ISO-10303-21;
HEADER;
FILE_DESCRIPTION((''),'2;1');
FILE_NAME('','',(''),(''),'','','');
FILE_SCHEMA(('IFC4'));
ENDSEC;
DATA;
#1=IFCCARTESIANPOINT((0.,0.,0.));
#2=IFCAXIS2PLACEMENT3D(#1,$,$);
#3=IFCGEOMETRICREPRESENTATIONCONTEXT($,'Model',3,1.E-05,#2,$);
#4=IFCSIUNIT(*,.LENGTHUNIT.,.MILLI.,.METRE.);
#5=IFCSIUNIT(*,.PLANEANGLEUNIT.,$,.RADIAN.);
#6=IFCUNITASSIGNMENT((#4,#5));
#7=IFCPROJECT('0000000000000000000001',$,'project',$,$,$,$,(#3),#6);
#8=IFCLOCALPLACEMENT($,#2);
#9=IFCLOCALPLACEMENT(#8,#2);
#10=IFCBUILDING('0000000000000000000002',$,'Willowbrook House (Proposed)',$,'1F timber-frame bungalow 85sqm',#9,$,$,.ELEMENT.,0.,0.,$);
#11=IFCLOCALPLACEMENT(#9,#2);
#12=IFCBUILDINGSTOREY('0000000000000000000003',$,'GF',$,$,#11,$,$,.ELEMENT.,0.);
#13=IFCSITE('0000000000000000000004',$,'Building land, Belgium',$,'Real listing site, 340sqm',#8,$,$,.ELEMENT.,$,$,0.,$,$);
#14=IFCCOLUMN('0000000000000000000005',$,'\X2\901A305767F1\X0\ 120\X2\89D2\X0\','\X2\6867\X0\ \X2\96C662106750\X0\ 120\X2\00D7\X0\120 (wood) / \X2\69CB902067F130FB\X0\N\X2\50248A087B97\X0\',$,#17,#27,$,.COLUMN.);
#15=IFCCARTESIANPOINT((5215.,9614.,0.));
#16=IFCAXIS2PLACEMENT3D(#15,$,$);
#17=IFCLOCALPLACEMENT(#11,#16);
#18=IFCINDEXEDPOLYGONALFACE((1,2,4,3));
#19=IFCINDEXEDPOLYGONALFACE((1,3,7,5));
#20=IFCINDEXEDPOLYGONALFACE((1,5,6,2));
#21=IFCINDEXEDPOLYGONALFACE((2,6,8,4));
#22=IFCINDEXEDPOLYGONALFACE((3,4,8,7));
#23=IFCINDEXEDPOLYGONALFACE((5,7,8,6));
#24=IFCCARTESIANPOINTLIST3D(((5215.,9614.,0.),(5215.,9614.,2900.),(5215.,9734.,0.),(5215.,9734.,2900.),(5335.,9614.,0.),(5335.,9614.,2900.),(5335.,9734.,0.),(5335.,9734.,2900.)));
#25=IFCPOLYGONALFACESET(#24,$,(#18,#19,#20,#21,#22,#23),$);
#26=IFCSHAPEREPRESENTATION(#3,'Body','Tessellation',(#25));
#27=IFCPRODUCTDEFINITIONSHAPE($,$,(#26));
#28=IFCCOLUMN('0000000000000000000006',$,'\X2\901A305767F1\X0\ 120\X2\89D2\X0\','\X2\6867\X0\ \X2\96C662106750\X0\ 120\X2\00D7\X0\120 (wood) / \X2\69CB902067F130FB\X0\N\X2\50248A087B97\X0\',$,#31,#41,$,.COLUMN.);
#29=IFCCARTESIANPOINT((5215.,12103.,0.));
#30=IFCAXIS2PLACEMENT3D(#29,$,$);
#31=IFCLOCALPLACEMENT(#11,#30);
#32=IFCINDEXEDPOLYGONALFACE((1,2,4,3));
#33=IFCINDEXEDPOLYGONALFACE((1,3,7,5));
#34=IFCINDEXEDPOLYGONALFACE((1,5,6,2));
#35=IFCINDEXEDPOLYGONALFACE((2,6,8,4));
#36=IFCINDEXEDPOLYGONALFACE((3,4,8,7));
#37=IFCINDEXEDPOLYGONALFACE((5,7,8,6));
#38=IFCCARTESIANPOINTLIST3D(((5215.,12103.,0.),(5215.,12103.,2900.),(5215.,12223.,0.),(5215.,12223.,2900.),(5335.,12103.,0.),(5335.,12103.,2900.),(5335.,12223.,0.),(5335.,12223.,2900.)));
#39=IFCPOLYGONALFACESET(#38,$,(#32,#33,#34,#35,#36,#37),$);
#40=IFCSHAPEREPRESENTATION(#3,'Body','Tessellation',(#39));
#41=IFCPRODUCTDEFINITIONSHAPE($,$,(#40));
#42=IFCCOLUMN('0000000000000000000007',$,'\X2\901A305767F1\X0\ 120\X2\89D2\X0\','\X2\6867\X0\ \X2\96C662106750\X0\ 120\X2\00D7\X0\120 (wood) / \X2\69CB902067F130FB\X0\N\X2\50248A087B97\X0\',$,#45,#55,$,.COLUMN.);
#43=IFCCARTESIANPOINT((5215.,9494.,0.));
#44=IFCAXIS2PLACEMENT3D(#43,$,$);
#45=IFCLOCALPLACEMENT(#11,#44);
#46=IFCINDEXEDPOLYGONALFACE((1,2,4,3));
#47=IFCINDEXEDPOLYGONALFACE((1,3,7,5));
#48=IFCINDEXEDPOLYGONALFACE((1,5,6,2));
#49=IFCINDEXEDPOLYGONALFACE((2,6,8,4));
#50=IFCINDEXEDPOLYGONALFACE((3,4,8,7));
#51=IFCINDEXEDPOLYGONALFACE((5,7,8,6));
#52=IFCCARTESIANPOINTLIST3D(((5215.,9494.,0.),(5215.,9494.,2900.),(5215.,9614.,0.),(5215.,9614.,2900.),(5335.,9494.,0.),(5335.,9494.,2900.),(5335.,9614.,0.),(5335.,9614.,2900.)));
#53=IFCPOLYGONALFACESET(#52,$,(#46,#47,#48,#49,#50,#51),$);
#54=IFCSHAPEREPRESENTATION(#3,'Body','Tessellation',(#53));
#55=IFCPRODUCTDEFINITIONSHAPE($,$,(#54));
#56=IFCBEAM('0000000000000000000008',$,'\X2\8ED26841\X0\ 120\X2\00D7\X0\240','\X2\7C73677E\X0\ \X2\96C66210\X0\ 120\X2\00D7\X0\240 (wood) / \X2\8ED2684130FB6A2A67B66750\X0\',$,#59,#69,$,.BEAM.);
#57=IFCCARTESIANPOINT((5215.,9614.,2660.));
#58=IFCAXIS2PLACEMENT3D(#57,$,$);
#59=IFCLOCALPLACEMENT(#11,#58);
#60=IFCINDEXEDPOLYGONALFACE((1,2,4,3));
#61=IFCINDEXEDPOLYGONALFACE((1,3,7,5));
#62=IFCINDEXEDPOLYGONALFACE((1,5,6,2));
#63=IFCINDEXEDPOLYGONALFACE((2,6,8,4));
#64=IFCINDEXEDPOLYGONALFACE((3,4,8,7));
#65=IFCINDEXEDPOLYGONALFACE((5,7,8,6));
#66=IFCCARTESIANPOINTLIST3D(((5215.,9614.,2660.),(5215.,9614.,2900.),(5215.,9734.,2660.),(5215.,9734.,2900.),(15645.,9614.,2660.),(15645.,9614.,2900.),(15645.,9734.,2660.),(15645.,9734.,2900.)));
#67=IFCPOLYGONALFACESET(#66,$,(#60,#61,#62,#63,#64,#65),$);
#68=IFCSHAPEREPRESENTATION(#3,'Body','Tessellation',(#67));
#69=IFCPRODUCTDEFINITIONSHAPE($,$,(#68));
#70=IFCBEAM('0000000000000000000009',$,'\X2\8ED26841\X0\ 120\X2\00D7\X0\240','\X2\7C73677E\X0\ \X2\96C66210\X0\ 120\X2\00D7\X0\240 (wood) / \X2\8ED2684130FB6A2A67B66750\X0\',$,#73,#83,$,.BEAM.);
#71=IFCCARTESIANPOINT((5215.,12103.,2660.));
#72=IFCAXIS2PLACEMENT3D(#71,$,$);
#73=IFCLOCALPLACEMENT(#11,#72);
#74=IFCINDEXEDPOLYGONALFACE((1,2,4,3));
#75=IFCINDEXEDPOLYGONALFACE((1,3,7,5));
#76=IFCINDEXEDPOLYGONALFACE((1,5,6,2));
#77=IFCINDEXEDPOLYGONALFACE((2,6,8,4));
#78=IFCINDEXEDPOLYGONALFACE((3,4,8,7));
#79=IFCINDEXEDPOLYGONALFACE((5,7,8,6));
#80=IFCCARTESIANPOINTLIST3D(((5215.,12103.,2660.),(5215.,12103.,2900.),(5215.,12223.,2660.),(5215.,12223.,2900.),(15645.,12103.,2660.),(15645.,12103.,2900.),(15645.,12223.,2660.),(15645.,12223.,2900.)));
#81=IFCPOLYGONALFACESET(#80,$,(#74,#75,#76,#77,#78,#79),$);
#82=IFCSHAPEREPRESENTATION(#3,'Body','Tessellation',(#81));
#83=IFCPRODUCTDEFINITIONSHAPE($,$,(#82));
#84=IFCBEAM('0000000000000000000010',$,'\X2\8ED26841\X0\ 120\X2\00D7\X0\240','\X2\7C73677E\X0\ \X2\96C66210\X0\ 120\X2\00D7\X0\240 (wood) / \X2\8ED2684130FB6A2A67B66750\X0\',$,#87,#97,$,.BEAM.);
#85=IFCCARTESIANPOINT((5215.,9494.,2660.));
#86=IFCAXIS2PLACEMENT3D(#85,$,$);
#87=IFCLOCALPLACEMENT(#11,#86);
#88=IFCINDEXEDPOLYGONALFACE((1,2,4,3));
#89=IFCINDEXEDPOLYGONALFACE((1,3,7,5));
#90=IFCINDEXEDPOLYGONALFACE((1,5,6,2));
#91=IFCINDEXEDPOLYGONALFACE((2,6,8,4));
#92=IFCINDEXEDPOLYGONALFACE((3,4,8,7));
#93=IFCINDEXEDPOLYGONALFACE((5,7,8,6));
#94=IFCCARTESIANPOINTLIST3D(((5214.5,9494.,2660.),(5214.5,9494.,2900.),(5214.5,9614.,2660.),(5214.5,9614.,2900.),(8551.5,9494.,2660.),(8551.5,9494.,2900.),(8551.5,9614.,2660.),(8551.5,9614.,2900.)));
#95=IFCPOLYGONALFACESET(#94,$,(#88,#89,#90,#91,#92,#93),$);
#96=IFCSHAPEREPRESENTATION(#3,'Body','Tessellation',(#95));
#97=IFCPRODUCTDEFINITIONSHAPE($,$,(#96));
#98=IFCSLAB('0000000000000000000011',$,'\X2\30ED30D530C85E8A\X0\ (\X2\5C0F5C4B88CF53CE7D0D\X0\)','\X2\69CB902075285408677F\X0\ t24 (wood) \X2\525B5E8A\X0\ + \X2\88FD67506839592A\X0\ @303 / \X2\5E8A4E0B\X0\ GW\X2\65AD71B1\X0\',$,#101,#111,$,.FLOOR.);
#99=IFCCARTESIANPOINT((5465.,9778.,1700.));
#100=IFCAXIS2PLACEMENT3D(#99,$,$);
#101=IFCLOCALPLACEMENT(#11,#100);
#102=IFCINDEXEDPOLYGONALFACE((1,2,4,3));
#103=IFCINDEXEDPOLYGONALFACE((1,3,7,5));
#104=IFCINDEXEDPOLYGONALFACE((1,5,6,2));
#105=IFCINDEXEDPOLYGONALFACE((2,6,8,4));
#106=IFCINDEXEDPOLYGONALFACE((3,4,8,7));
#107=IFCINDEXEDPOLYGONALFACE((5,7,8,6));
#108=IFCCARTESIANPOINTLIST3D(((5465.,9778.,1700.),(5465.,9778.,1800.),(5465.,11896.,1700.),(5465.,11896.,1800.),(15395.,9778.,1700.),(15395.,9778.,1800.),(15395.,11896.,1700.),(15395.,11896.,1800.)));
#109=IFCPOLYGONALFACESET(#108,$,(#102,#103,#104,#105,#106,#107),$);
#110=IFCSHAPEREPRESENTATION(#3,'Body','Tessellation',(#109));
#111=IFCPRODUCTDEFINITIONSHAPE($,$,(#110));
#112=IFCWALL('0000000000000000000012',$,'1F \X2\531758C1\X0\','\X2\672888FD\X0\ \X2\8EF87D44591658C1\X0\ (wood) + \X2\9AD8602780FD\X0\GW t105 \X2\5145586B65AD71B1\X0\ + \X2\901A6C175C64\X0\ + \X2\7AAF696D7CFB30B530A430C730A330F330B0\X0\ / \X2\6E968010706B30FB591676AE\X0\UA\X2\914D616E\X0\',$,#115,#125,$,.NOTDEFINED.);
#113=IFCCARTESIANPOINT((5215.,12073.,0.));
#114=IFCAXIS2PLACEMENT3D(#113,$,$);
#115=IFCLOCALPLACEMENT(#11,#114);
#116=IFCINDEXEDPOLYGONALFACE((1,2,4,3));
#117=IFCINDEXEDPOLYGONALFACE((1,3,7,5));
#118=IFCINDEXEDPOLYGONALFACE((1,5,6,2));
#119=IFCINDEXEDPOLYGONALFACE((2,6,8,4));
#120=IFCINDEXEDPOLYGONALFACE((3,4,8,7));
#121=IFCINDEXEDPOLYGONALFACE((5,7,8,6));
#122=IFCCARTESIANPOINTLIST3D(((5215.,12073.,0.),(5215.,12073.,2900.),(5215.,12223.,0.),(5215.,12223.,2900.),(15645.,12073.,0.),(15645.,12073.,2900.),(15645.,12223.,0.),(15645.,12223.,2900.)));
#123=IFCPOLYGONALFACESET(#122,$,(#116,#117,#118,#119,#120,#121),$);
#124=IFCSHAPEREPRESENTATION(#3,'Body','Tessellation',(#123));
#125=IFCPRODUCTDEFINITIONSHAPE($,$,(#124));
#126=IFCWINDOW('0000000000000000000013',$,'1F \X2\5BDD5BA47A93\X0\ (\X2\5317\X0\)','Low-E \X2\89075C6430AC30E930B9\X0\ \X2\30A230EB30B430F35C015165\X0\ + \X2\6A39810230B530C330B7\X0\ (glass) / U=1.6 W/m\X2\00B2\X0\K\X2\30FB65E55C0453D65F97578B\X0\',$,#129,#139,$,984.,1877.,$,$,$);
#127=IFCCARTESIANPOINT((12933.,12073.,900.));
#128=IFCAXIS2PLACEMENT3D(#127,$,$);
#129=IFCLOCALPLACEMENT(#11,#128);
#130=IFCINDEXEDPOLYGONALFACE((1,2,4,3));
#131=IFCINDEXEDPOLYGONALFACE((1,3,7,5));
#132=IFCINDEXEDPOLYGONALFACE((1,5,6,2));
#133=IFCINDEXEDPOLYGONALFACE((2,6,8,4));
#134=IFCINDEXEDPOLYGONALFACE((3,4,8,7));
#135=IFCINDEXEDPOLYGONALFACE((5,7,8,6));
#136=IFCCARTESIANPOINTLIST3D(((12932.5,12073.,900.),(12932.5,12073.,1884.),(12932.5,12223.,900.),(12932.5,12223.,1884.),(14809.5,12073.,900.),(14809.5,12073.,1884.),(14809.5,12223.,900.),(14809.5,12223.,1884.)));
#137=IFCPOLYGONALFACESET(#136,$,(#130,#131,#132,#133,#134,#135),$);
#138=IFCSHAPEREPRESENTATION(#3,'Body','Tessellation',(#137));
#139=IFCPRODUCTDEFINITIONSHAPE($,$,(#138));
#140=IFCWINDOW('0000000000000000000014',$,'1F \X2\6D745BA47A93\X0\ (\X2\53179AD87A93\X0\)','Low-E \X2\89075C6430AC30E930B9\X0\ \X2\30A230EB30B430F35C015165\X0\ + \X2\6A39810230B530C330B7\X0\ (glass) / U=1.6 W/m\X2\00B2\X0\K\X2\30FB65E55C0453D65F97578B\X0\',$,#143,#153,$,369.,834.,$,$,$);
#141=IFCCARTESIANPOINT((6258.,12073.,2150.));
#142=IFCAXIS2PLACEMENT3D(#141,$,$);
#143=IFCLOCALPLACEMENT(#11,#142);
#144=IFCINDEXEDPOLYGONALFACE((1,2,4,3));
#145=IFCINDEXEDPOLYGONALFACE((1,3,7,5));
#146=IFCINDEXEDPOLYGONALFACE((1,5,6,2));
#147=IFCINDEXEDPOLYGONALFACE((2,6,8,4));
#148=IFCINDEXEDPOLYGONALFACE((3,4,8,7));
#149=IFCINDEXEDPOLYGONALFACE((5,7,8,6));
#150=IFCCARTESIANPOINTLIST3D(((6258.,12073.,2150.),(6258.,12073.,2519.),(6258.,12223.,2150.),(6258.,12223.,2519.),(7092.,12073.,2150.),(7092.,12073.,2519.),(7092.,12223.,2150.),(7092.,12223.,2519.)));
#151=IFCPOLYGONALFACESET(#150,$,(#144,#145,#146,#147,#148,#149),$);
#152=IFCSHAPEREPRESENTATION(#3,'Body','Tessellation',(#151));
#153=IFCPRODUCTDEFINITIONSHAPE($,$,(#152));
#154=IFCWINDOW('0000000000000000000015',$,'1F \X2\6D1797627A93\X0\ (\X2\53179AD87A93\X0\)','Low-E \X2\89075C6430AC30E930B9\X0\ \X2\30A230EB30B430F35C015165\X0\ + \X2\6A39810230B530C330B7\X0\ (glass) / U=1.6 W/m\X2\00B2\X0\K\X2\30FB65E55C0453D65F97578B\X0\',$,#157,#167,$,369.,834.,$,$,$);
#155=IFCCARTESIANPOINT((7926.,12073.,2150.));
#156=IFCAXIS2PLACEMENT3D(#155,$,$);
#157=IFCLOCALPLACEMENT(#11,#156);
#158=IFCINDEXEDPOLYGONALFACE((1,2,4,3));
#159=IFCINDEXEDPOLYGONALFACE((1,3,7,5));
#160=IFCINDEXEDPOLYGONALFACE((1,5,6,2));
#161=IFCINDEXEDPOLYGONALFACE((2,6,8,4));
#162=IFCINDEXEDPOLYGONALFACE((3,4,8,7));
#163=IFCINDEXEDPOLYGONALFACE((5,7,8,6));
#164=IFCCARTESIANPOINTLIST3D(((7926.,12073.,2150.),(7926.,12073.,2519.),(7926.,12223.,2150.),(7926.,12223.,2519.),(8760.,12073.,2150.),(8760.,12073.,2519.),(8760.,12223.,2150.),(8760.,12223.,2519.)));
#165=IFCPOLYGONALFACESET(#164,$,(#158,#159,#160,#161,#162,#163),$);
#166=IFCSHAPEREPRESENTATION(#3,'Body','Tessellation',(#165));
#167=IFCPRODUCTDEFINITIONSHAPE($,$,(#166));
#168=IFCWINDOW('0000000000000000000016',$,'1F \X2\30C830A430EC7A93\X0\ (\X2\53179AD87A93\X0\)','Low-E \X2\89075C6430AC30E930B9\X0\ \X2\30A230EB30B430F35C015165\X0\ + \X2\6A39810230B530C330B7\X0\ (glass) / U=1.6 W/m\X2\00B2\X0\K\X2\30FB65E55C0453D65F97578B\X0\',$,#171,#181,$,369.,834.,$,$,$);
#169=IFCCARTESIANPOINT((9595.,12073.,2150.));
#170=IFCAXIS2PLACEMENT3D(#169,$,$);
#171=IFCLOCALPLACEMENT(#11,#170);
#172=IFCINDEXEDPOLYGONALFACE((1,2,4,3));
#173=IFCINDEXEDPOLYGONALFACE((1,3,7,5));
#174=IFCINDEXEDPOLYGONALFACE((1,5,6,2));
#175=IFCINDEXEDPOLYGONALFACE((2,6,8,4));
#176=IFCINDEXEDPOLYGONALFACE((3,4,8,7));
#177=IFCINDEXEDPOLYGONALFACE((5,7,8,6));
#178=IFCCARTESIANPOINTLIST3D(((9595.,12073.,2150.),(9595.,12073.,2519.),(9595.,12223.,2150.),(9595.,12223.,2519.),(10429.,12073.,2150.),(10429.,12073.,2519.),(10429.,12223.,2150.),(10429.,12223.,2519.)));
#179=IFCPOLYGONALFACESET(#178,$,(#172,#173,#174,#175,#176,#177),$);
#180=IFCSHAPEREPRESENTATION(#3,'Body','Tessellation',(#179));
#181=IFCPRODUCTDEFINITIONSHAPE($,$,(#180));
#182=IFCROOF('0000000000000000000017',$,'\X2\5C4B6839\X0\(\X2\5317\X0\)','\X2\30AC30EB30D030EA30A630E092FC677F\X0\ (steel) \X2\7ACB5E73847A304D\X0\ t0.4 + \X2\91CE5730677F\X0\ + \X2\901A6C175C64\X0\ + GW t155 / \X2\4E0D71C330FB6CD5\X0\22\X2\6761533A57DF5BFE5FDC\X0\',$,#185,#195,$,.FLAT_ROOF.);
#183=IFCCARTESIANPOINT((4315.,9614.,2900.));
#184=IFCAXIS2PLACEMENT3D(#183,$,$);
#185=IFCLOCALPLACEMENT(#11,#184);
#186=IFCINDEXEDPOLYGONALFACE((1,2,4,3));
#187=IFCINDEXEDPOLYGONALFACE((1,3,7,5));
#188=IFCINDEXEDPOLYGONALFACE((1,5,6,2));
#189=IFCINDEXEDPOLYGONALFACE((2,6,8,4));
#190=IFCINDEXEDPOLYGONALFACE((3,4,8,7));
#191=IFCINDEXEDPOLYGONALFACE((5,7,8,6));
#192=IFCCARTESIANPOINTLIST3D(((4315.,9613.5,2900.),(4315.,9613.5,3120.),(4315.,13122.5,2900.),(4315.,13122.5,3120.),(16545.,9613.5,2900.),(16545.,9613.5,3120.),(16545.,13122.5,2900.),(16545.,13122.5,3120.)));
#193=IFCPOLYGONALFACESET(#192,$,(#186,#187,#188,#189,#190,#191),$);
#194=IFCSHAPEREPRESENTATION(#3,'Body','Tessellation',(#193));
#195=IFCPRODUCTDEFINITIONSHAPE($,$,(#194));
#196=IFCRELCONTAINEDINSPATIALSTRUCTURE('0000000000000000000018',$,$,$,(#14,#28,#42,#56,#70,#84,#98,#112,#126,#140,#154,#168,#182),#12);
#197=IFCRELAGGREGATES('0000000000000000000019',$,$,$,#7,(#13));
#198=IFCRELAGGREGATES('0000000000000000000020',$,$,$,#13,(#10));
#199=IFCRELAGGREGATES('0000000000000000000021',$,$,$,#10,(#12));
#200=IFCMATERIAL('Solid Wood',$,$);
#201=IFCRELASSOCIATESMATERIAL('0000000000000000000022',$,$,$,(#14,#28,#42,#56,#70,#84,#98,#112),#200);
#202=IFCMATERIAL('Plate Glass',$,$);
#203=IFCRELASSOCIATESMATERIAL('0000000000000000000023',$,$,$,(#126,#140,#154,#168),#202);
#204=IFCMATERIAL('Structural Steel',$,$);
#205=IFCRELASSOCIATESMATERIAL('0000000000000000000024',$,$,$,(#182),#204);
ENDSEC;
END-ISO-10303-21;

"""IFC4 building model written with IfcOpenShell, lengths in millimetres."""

from ifc_helpers import new_model, si_unit, frame, frame_2d, origin, place, context, project, spatial, rectangle, extrude, material, element, fill, save


model = new_model("IFC4")

# Units and contexts
model_context = context("Model", 3, precision=1e-05, world=origin())
ifc_project = project(units=[si_unit("LENGTHUNIT", "METRE", prefix="MILLI"), si_unit("PLANEANGLEUNIT", "RADIAN")], contexts=[model_context])

# Site, building, storey
site_placement = place(None, origin())
site = spatial("IfcSite", under=ifc_project, at=site_placement, Name="Building land, Belgium", ObjectType="Real listing site, 340sqm", CompositionType="ELEMENT", RefElevation=0.0)
building_placement = place(site_placement, origin())
building = spatial("IfcBuilding", under=site, at=building_placement, Name="Willowbrook House (Proposed)", ObjectType="1F timber-frame bungalow 85sqm", CompositionType="ELEMENT", ElevationOfRefHeight=0.0, ElevationOfTerrain=0.0)
storey_placement = place(building_placement, origin())
storey = spatial("IfcBuildingStorey", under=building, at=storey_placement, Name="GF", CompositionType="ELEMENT", Elevation=0.0)

# Columns
ifc_material_1 = material(Name="Solid Wood")
column_1_placement = place(storey_placement, frame((5215.0, 9614.0, 0.0)))
element("IfcColumn", 1, at=column_1_placement, inside=storey, material=ifc_material_1, Name="通し柱 120角", Description="桧 集成材 120×120 (wood) / 構造柱・N値計算", PredefinedType="COLUMN", context=model_context, shape_type="SweptSolid", body=[
    extrude(rectangle(XDim=120.0, YDim=120.0, at=frame_2d((60.0, 60.0))), frame((5215.0, 9614.0, 0.0)), (0.0, 0.0, 1.0), 2900.0),
])
column_2_placement = place(storey_placement, frame((5215.0, 12103.0, 0.0)))
element("IfcColumn", 2, at=column_2_placement, inside=storey, material=ifc_material_1, Name="通し柱 120角", Description="桧 集成材 120×120 (wood) / 構造柱・N値計算", PredefinedType="COLUMN", context=model_context, shape_type="SweptSolid", body=[
    extrude(rectangle(XDim=120.0, YDim=120.0, at=frame_2d((60.0, 60.0))), frame((5215.0, 12103.0, 0.0)), (0.0, 0.0, 1.0), 2900.0),
])
column_3_placement = place(storey_placement, frame((5215.0, 9494.0, 0.0)))
element("IfcColumn", 3, at=column_3_placement, inside=storey, material=ifc_material_1, Name="通し柱 120角", Description="桧 集成材 120×120 (wood) / 構造柱・N値計算", PredefinedType="COLUMN", context=model_context, shape_type="SweptSolid", body=[
    extrude(rectangle(XDim=120.0, YDim=120.0, at=frame_2d((60.0, 60.0))), frame((5215.0, 9494.0, 0.0)), (0.0, 0.0, 1.0), 2900.0),
])

# Beams
beam_1_placement = place(storey_placement, frame((5215.0, 9614.0, 2660.0)))
element("IfcBeam", 4, at=beam_1_placement, inside=storey, material=ifc_material_1, Name="軒桁 120×240", Description="米松 集成 120×240 (wood) / 軒桁・横架材", PredefinedType="BEAM", context=model_context, shape_type="SweptSolid", body=[
    extrude(rectangle(XDim=10430.0, YDim=120.0, at=frame_2d((5215.0, 60.0))), frame((5215.0, 9614.0, 2660.0)), (0.0, 0.0, 1.0), 240.0),
])
beam_2_placement = place(storey_placement, frame((5215.0, 12103.0, 2660.0)))
element("IfcBeam", 5, at=beam_2_placement, inside=storey, material=ifc_material_1, Name="軒桁 120×240", Description="米松 集成 120×240 (wood) / 軒桁・横架材", PredefinedType="BEAM", context=model_context, shape_type="SweptSolid", body=[
    extrude(rectangle(XDim=10430.0, YDim=120.0, at=frame_2d((5215.0, 60.0))), frame((5215.0, 12103.0, 2660.0)), (0.0, 0.0, 1.0), 240.0),
])
beam_3_placement = place(storey_placement, frame((5215.0, 9494.0, 2660.0)))
element("IfcBeam", 6, at=beam_3_placement, inside=storey, material=ifc_material_1, Name="軒桁 120×240", Description="米松 集成 120×240 (wood) / 軒桁・横架材", PredefinedType="BEAM", context=model_context, shape_type="SweptSolid", body=[
    extrude(rectangle(XDim=3337.0, YDim=120.0, at=frame_2d((1668.0, 60.0))), frame((5215.0, 9494.0, 2660.0)), (0.0, 0.0, 1.0), 240.0),
])

# Slab
slab_1_placement = place(storey_placement, frame((5465.0, 9778.0, 1700.0)))
element("IfcSlab", 7, at=slab_1_placement, inside=storey, material=ifc_material_1, Name="ロフト床 (小屋裏収納)", Description="構造用合板 t24 (wood) 剛床 + 製材根太 @303 / 床下 GW断熱", PredefinedType="FLOOR", context=model_context, shape_type="SweptSolid", body=[
    extrude(rectangle(XDim=9930.0, YDim=2118.0, at=frame_2d((4965.0, 1059.0))), frame((5465.0, 9778.0, 1700.0)), (0.0, 0.0, 1.0), 100.0),
])

# Wall, openings, windows
wall_1_placement = place(storey_placement, frame((5215.0, 12073.0, 0.0)))
wall_1 = element("IfcWall", 8, at=wall_1_placement, inside=storey, material=ifc_material_1, Name="1F 北壁", Description="木製 軸組外壁 (wood) + 高性能GW t105 充填断熱 + 通気層 + 窯業系サイディング / 準耐火・外皮UA配慮", PredefinedType="NOTDEFINED", context=model_context, shape_type="SweptSolid", body=[
    extrude(rectangle(XDim=10430.0, YDim=150.0, at=frame_2d((5215.0, 75.0))), frame((5215.0, 12073.0, 0.0)), (0.0, 0.0, 1.0), 2900.0),
])
opening_1_placement = place(storey_placement, frame((12933.0, 12073.0, 900.0)))
opening_1 = element("IfcOpeningElement", 9, at=opening_1_placement, cuts=wall_1, PredefinedType="NOTDEFINED", context=model_context, shape_type="SweptSolid", body=[
    extrude(rectangle(XDim=1877.0, YDim=150.0, at=frame_2d((938.0, 75.0))), frame((12933.0, 12073.0, 900.0)), (0.0, 0.0, 1.0), 984.0),
])
opening_2_placement = place(storey_placement, frame((6258.0, 12073.0, 2150.0)))
opening_2 = element("IfcOpeningElement", 10, at=opening_2_placement, cuts=wall_1, PredefinedType="NOTDEFINED", context=model_context, shape_type="SweptSolid", body=[
    extrude(rectangle(XDim=834.0, YDim=150.0, at=frame_2d((417.0, 75.0))), frame((6258.0, 12073.0, 2150.0)), (0.0, 0.0, 1.0), 369.0),
])
opening_3_placement = place(storey_placement, frame((7926.0, 12073.0, 2150.0)))
opening_3 = element("IfcOpeningElement", 11, at=opening_3_placement, cuts=wall_1, PredefinedType="NOTDEFINED", context=model_context, shape_type="SweptSolid", body=[
    extrude(rectangle(XDim=834.0, YDim=150.0, at=frame_2d((417.0, 75.0))), frame((7926.0, 12073.0, 2150.0)), (0.0, 0.0, 1.0), 369.0),
])
opening_4_placement = place(storey_placement, frame((9595.0, 12073.0, 2150.0)))
opening_4 = element("IfcOpeningElement", 12, at=opening_4_placement, cuts=wall_1, PredefinedType="NOTDEFINED", context=model_context, shape_type="SweptSolid", body=[
    extrude(rectangle(XDim=834.0, YDim=150.0, at=frame_2d((417.0, 75.0))), frame((9595.0, 12073.0, 2150.0)), (0.0, 0.0, 1.0), 369.0),
])
ifc_material_2 = material(Name="Plate Glass")
window_1_placement = place(storey_placement, frame((12933.0, 12073.0, 900.0)))
window_1 = element("IfcWindow", 13, at=window_1_placement, inside=storey, material=ifc_material_2, Name="1F 寝室窓 (北)", Description="Low-E 複層ガラス アルゴン封入 + 樹脂サッシ (glass) / U=1.6 W/m²K・日射取得型", OverallHeight=984.0, OverallWidth=1877.0, context=model_context, shape_type="SweptSolid", body=[
    extrude(rectangle(XDim=1877.0, YDim=150.0, at=frame_2d((938.0, 75.0))), frame((12933.0, 12073.0, 900.0)), (0.0, 0.0, 1.0), 984.0),
])
fill(opening_1, window_1)
window_2_placement = place(storey_placement, frame((6258.0, 12073.0, 2150.0)))
window_2 = element("IfcWindow", 14, at=window_2_placement, inside=storey, material=ifc_material_2, Name="1F 浴室窓 (北高窓)", Description="Low-E 複層ガラス アルゴン封入 + 樹脂サッシ (glass) / U=1.6 W/m²K・日射取得型", OverallHeight=369.0, OverallWidth=834.0, context=model_context, shape_type="SweptSolid", body=[
    extrude(rectangle(XDim=834.0, YDim=150.0, at=frame_2d((417.0, 75.0))), frame((6258.0, 12073.0, 2150.0)), (0.0, 0.0, 1.0), 369.0),
])
fill(opening_2, window_2)
window_3_placement = place(storey_placement, frame((7926.0, 12073.0, 2150.0)))
window_3 = element("IfcWindow", 15, at=window_3_placement, inside=storey, material=ifc_material_2, Name="1F 洗面窓 (北高窓)", Description="Low-E 複層ガラス アルゴン封入 + 樹脂サッシ (glass) / U=1.6 W/m²K・日射取得型", OverallHeight=369.0, OverallWidth=834.0, context=model_context, shape_type="SweptSolid", body=[
    extrude(rectangle(XDim=834.0, YDim=150.0, at=frame_2d((417.0, 75.0))), frame((7926.0, 12073.0, 2150.0)), (0.0, 0.0, 1.0), 369.0),
])
fill(opening_3, window_3)
window_4_placement = place(storey_placement, frame((9595.0, 12073.0, 2150.0)))
window_4 = element("IfcWindow", 16, at=window_4_placement, inside=storey, material=ifc_material_2, Name="1F トイレ窓 (北高窓)", Description="Low-E 複層ガラス アルゴン封入 + 樹脂サッシ (glass) / U=1.6 W/m²K・日射取得型", OverallHeight=369.0, OverallWidth=834.0, context=model_context, shape_type="SweptSolid", body=[
    extrude(rectangle(XDim=834.0, YDim=150.0, at=frame_2d((417.0, 75.0))), frame((9595.0, 12073.0, 2150.0)), (0.0, 0.0, 1.0), 369.0),
])
fill(opening_4, window_4)

# Roof
ifc_material_3 = material(Name="Structural Steel")
roof_placement = place(storey_placement, frame((4315.0, 9614.0, 2900.0)))
element("IfcRoof", 17, at=roof_placement, inside=storey, material=ifc_material_3, Name="屋根(北)", Description="ガルバリウム鋼板 (steel) 立平葺き t0.4 + 野地板 + 通気層 + GW t155 / 不燃・法22条区域対応", PredefinedType="FLAT_ROOF", context=model_context, shape_type="SweptSolid", body=[
    extrude(rectangle(XDim=12230.0, YDim=3509.0, at=frame_2d((6115.0, 1754.0))), frame((4315.0, 9614.0, 2900.0)), (0.0, 0.0, 1.0), 220.0),
])

save(model, "model.ifc")
